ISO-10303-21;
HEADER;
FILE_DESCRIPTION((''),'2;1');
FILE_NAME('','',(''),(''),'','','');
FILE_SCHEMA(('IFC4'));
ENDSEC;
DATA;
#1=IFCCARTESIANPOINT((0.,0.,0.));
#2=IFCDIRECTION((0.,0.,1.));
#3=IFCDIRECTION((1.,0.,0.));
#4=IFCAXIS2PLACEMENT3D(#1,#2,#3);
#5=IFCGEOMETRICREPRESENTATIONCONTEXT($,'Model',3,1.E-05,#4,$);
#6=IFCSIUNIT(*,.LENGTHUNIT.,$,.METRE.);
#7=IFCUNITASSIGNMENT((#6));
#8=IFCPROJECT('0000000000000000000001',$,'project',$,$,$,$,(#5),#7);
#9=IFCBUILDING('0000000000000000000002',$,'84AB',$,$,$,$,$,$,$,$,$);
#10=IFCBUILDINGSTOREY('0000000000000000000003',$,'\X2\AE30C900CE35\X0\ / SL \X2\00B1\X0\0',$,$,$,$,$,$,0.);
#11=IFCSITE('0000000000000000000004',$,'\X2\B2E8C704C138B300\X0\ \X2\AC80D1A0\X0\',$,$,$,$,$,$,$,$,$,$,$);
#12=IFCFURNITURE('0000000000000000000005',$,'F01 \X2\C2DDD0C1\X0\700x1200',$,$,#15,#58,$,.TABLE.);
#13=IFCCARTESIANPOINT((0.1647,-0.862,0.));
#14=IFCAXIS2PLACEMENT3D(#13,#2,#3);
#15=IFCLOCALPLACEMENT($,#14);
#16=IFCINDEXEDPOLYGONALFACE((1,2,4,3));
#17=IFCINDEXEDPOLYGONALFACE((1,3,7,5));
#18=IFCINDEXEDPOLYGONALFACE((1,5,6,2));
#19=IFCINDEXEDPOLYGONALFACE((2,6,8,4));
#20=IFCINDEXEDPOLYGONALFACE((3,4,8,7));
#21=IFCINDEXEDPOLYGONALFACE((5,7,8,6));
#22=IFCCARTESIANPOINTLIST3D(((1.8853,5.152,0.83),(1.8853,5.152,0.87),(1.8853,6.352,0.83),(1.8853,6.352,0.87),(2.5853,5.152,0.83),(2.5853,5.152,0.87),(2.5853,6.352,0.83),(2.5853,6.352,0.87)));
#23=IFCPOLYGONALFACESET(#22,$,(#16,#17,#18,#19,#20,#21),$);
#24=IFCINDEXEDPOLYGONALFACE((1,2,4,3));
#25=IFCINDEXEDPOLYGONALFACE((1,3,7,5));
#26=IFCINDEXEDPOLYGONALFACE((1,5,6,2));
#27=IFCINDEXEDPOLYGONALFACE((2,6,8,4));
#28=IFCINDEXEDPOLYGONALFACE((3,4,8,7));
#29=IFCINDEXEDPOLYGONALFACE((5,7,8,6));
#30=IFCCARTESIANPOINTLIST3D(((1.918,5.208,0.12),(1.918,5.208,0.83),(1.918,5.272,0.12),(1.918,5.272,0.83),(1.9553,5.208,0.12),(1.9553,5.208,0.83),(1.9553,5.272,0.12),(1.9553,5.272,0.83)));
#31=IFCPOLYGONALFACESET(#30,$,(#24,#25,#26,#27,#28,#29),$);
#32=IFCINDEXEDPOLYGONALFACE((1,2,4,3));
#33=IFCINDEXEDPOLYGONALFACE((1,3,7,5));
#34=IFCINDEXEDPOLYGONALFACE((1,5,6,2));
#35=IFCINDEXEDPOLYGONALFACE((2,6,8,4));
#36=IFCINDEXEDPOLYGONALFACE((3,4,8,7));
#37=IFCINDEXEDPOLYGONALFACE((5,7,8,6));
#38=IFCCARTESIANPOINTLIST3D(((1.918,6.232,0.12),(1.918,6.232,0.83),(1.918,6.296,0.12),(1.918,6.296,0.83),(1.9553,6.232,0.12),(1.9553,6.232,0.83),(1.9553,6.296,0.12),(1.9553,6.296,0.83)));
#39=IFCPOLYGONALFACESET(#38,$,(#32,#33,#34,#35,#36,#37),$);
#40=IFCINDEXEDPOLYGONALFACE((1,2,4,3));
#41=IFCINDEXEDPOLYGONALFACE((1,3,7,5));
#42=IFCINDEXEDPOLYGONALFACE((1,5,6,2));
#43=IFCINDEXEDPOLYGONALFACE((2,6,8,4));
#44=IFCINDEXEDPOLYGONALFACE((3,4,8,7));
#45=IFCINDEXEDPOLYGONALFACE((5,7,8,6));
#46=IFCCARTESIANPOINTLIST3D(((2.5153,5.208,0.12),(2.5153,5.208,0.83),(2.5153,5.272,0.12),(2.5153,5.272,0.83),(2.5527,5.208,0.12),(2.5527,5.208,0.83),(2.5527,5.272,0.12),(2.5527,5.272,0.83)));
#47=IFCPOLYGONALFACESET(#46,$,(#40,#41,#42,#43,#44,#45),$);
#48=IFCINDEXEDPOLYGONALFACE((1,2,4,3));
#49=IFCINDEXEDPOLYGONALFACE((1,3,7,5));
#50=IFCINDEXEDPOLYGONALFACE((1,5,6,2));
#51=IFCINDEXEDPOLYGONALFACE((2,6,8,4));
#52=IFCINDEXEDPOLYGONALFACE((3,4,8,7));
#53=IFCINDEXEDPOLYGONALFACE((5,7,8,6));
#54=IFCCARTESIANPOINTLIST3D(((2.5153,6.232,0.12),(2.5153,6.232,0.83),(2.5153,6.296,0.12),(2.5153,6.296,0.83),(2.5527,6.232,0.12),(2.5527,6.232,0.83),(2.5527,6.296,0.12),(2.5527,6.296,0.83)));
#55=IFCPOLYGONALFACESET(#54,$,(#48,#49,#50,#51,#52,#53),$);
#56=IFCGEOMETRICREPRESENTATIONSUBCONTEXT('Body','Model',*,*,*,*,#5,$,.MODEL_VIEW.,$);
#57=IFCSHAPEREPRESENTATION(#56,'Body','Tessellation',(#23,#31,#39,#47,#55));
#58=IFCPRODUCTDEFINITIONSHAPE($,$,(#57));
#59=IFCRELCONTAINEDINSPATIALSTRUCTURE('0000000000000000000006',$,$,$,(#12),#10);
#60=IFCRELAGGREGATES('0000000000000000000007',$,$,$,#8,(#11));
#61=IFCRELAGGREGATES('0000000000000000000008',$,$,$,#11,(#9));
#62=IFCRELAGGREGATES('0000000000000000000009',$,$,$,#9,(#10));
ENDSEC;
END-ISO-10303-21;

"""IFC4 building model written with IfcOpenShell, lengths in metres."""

from ifc_helpers import new_model, si_unit, frame, origin_with_axes, place, context, subcontext, project, spatial, polyline, outline, extrude, element, save


model = new_model("IFC4")

# Units and contexts
model_context = context("Model", 3, precision=1e-05, world=origin_with_axes())
body_context = subcontext(model_context, "Body", "Model", "MODEL_VIEW")
ifc_project = project(units=[si_unit("LENGTHUNIT", "METRE")], contexts=[model_context])

# Site, building, storey
site = spatial("IfcSite", under=ifc_project, Name="단위세대 검토")
building = spatial("IfcBuilding", under=site, Name="84AB")
storey = spatial("IfcBuildingStorey", under=building, Name="기준층 / SL ±0", Elevation=0.0)

# Furniture
furniture_placement = place(None, frame((0.1647, -0.862, 0.0), z_axis=(0.0, 0.0, 1.0), x_axis=(1.0, 0.0, 0.0)))
element("IfcFurniture", 1, at=furniture_placement, inside=storey, Name="F01 식탁700x1200", PredefinedType="TABLE", context=body_context, shape_type="SweptSolid", body=[
    extrude(outline(polyline([(2.5853, 6.352), (2.5853, 5.152), (1.8853, 5.152), (1.8853, 6.352), (2.5853, 6.352)])), frame((0.0, 0.0, 0.83)), (0.0, 0.0, 1.0), 0.04),
    extrude(outline(polyline([(1.9553, 5.208), (1.9553, 5.272), (1.918, 5.272), (1.918, 5.208), (1.9553, 5.208)])), frame((0.0, 0.0, 0.12)), (0.0, 0.0, 1.0), 0.71),
    extrude(outline(polyline([(1.9553, 6.232), (1.9553, 6.296), (1.918, 6.296), (1.918, 6.232), (1.9553, 6.232)])), frame((0.0, 0.0, 0.12)), (0.0, 0.0, 1.0), 0.71),
    extrude(outline(polyline([(2.5527, 5.208), (2.5527, 5.272), (2.5153, 5.272), (2.5153, 5.208), (2.5527, 5.208)])), frame((0.0, 0.0, 0.12)), (0.0, 0.0, 1.0), 0.71),
    extrude(outline(polyline([(2.5527, 6.232), (2.5527, 6.296), (2.5153, 6.296), (2.5153, 6.232), (2.5527, 6.232)])), frame((0.0, 0.0, 0.12)), (0.0, 0.0, 1.0), 0.71),
])

save(model, "model.ifc")
